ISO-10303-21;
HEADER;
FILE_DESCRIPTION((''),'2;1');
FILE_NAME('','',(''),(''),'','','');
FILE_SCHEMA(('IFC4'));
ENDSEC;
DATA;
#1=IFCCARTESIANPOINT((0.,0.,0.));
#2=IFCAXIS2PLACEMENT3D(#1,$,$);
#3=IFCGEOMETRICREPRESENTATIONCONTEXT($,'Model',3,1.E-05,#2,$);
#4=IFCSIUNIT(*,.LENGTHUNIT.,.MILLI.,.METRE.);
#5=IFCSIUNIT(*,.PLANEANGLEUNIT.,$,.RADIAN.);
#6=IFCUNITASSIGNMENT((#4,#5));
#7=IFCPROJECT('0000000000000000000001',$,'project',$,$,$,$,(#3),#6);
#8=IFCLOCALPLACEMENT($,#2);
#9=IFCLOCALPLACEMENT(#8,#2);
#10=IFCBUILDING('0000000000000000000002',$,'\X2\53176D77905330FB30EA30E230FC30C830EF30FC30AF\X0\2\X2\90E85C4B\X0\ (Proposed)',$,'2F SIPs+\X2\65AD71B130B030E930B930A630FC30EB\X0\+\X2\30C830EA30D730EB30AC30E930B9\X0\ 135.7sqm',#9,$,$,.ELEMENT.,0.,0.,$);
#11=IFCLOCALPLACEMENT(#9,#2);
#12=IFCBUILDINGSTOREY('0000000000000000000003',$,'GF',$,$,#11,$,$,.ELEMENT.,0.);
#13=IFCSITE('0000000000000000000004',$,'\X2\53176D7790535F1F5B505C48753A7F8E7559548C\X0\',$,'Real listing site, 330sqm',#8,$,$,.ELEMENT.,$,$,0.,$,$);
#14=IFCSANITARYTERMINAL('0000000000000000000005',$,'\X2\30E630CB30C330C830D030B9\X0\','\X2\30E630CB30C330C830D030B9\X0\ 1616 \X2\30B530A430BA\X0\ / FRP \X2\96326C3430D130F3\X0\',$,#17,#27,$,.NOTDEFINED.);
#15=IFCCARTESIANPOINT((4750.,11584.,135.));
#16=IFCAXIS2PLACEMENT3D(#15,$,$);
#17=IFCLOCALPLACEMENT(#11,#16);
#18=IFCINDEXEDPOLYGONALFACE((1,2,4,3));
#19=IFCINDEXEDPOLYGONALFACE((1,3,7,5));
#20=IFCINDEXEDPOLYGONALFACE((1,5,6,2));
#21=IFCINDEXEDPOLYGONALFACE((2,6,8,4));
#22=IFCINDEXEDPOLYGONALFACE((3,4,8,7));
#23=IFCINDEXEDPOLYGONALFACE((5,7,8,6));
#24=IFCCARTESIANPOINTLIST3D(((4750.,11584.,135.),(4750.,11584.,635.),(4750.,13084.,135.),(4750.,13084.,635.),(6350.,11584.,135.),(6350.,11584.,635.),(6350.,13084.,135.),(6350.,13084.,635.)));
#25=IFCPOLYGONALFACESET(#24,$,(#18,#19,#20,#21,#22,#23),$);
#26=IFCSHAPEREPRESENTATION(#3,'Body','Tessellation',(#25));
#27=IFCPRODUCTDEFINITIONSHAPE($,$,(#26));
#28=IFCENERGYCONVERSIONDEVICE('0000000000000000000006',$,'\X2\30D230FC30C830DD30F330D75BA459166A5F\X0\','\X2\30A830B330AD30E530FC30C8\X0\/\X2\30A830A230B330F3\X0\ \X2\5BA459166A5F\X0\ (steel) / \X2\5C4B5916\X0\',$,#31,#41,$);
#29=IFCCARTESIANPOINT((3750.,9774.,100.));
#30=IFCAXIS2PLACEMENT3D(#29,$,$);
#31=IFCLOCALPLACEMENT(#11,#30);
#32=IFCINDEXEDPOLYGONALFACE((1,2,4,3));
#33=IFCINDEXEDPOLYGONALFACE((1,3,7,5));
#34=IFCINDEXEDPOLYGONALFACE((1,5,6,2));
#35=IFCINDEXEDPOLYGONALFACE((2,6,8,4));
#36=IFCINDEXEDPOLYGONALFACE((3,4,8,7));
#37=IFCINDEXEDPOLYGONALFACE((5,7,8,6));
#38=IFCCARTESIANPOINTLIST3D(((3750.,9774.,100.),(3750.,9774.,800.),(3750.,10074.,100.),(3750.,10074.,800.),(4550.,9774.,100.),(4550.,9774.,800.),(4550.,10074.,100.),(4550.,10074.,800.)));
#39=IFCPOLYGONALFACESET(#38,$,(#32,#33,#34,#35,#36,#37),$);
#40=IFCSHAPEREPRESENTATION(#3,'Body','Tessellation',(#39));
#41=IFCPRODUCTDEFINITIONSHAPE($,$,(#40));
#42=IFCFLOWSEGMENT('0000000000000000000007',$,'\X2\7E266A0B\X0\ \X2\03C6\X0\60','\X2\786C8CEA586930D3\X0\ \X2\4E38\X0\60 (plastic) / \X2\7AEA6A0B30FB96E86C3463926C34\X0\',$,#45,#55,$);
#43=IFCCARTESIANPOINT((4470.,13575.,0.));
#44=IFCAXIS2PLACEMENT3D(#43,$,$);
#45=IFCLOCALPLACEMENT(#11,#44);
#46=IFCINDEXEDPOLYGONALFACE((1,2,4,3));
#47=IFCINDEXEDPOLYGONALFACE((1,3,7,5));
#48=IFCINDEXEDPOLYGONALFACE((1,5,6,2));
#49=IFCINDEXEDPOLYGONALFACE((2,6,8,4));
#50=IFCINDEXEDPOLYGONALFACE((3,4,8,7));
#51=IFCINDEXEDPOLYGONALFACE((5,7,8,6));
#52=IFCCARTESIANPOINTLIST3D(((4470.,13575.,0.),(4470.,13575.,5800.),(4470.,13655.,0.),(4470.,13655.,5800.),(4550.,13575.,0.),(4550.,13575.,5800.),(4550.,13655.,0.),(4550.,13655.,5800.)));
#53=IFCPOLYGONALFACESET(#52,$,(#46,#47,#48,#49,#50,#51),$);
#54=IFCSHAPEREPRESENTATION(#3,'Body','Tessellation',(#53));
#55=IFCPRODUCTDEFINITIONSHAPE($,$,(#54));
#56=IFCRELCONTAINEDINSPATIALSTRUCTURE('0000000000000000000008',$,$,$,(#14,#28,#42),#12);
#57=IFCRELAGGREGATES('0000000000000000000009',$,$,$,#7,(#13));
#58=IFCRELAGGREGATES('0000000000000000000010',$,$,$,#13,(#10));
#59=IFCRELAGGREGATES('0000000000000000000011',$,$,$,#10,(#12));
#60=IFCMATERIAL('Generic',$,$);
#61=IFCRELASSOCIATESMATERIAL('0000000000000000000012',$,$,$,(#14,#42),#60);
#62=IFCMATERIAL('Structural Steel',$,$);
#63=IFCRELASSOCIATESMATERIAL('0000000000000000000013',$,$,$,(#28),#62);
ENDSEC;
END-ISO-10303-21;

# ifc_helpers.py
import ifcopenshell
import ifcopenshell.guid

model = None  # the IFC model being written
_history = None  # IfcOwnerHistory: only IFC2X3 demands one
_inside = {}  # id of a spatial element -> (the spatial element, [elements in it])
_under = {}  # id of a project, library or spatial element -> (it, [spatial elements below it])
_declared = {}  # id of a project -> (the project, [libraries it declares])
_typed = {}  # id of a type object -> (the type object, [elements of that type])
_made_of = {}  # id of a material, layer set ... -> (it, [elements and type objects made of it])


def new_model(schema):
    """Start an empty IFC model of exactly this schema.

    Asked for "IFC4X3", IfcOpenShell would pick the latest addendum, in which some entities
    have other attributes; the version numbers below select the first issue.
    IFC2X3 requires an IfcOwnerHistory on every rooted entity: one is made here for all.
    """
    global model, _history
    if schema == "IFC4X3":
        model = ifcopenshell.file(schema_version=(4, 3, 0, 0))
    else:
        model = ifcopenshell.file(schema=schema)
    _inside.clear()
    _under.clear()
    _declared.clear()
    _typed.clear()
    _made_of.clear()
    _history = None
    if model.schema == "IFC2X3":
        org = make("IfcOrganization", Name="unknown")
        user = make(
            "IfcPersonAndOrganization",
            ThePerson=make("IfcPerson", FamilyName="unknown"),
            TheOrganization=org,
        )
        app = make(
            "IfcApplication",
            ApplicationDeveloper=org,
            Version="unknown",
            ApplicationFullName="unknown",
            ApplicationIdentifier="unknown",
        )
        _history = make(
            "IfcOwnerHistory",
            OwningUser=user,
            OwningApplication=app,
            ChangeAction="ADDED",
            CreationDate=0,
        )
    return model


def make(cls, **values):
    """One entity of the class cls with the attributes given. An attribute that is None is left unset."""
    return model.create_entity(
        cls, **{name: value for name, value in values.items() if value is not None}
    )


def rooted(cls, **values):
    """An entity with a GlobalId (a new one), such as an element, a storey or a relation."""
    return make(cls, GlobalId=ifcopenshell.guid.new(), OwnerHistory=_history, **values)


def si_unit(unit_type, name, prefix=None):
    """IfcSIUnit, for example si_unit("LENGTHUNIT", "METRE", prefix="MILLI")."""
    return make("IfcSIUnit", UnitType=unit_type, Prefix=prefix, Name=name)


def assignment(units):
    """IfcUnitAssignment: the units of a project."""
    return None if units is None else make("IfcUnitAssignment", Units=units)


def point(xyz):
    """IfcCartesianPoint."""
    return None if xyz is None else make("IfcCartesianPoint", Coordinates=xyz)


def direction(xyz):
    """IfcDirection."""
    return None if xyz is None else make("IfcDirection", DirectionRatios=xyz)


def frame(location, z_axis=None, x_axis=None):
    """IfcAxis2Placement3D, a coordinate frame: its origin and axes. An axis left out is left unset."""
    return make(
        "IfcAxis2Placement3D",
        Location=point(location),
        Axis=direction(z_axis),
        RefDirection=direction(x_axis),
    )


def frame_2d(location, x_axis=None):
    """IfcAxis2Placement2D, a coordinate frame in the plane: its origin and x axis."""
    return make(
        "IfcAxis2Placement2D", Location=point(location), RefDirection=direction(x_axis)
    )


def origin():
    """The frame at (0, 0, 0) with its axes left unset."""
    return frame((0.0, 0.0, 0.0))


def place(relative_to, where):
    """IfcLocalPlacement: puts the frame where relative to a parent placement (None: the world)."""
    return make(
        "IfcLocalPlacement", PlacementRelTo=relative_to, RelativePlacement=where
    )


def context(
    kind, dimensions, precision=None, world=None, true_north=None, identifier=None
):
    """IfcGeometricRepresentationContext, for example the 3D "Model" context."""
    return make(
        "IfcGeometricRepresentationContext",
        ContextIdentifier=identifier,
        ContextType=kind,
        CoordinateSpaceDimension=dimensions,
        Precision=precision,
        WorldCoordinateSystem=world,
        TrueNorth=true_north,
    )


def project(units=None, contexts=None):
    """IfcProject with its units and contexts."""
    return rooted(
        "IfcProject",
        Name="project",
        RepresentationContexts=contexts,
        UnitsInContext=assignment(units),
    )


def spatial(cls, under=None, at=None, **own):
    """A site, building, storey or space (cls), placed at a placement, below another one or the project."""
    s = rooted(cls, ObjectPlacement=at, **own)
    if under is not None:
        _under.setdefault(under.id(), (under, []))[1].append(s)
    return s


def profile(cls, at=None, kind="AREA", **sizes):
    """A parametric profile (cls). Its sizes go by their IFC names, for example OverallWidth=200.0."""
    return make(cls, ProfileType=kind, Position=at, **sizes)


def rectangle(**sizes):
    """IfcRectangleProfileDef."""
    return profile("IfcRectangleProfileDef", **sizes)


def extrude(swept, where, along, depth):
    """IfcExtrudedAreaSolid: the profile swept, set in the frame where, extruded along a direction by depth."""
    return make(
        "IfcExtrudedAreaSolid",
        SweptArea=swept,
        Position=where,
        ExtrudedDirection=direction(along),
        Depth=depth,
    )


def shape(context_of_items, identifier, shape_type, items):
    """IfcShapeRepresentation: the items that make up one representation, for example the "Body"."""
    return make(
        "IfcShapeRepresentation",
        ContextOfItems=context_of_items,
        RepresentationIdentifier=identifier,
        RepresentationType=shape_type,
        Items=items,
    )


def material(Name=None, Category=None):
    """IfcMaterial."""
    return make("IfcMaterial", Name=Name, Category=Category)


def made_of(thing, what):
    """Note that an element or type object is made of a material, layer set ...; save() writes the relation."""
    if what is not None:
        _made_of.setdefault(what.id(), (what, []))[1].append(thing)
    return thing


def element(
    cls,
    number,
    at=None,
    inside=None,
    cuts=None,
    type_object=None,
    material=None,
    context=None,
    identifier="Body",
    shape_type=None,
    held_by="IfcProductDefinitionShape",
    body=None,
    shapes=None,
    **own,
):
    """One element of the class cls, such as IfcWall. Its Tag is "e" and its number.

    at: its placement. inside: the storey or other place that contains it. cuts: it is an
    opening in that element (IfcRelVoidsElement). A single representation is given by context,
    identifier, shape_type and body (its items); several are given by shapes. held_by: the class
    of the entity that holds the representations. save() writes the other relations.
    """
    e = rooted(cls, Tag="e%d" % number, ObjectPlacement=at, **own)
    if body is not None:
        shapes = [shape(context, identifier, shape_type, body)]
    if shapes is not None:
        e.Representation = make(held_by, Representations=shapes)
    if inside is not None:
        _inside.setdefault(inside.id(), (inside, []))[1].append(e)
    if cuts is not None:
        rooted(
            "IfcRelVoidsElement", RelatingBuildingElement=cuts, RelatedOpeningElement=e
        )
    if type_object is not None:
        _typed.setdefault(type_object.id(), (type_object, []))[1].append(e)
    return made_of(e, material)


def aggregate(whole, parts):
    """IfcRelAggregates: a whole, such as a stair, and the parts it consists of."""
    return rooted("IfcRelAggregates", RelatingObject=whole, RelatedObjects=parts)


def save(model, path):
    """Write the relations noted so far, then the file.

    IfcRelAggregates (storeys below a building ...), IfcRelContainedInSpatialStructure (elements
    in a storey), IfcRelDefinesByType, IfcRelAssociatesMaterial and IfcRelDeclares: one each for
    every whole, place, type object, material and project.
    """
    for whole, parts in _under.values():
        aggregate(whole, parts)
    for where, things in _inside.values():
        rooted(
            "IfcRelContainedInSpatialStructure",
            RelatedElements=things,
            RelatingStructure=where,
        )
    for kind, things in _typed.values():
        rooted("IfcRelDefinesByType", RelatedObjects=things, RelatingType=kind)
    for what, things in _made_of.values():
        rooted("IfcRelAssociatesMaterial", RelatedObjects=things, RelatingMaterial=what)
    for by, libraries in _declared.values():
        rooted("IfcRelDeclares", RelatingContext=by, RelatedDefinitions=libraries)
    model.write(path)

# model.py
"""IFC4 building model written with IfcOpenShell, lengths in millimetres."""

from ifc_helpers import new_model, si_unit, frame, frame_2d, origin, place, context, project, spatial, rectangle, extrude, material, element, save


model = new_model("IFC4")

# Units and contexts
model_context = context("Model", 3, precision=1e-05, world=origin())
ifc_project = project(units=[si_unit("LENGTHUNIT", "METRE", prefix="MILLI"), si_unit("PLANEANGLEUNIT", "RADIAN")], contexts=[model_context])

# Site, building, storey
site_placement = place(None, origin())
site = spatial("IfcSite", under=ifc_project, at=site_placement, Name="北海道弟子屈町美留和", ObjectType="Real listing site, 330sqm", CompositionType="ELEMENT", RefElevation=0.0)
building_placement = place(site_placement, origin())
building = spatial("IfcBuilding", under=site, at=building_placement, Name="北海道・リモートワーク2部屋 (Proposed)", ObjectType="2F SIPs+断熱グラスウール+トリプルガラス 135.7sqm", CompositionType="ELEMENT", ElevationOfRefHeight=0.0, ElevationOfTerrain=0.0)
storey_placement = place(building_placement, origin())
storey = spatial("IfcBuildingStorey", under=building, at=storey_placement, Name="GF", CompositionType="ELEMENT", Elevation=0.0)

# Shared definitions
ifc_material_1 = material(Name="Generic")

# Sanitary terminal
sanitary_terminal_placement = place(storey_placement, frame((4750.0, 11584.0, 135.0)))
element("IfcSanitaryTerminal", 1, at=sanitary_terminal_placement, inside=storey, material=ifc_material_1, Name="ユニットバス", Description="ユニットバス 1616 サイズ / FRP 防水パン", PredefinedType="NOTDEFINED", context=model_context, shape_type="SweptSolid", body=[
    extrude(rectangle(XDim=1600.0, YDim=1500.0, at=frame_2d((800.0, 750.0))), frame((4750.0, 11584.0, 135.0)), (0.0, 0.0, 1.0), 500.0),
])

# Energy conversion device
ifc_material_2 = material(Name="Structural Steel")
energy_conversion_device_placement = place(storey_placement, frame((3750.0, 9774.0, 100.0)))
element("IfcEnergyConversionDevice", 2, at=energy_conversion_device_placement, inside=storey, material=ifc_material_2, Name="ヒートポンプ室外機", Description="エコキュート/エアコン 室外機 (steel) / 屋外", context=model_context, shape_type="SweptSolid", body=[
    extrude(rectangle(XDim=800.0, YDim=300.0, at=frame_2d((400.0, 150.0))), frame((3750.0, 9774.0, 100.0)), (0.0, 0.0, 1.0), 700.0),
])

# Flow segment
flow_segment_placement = place(storey_placement, frame((4470.0, 13575.0, 0.0)))
element("IfcFlowSegment", 3, at=flow_segment_placement, inside=storey, material=ifc_material_1, Name="縦樋 φ60", Description="硬質塩ビ 丸60 (plastic) / 竪樋・雨水排水", context=model_context, shape_type="SweptSolid", body=[
    extrude(rectangle(XDim=80.0, YDim=80.0, at=frame_2d((40.0, 40.0))), frame((4470.0, 13575.0, 0.0)), (0.0, 0.0, 1.0), 5800.0),
])

save(model, "model.ifc")
